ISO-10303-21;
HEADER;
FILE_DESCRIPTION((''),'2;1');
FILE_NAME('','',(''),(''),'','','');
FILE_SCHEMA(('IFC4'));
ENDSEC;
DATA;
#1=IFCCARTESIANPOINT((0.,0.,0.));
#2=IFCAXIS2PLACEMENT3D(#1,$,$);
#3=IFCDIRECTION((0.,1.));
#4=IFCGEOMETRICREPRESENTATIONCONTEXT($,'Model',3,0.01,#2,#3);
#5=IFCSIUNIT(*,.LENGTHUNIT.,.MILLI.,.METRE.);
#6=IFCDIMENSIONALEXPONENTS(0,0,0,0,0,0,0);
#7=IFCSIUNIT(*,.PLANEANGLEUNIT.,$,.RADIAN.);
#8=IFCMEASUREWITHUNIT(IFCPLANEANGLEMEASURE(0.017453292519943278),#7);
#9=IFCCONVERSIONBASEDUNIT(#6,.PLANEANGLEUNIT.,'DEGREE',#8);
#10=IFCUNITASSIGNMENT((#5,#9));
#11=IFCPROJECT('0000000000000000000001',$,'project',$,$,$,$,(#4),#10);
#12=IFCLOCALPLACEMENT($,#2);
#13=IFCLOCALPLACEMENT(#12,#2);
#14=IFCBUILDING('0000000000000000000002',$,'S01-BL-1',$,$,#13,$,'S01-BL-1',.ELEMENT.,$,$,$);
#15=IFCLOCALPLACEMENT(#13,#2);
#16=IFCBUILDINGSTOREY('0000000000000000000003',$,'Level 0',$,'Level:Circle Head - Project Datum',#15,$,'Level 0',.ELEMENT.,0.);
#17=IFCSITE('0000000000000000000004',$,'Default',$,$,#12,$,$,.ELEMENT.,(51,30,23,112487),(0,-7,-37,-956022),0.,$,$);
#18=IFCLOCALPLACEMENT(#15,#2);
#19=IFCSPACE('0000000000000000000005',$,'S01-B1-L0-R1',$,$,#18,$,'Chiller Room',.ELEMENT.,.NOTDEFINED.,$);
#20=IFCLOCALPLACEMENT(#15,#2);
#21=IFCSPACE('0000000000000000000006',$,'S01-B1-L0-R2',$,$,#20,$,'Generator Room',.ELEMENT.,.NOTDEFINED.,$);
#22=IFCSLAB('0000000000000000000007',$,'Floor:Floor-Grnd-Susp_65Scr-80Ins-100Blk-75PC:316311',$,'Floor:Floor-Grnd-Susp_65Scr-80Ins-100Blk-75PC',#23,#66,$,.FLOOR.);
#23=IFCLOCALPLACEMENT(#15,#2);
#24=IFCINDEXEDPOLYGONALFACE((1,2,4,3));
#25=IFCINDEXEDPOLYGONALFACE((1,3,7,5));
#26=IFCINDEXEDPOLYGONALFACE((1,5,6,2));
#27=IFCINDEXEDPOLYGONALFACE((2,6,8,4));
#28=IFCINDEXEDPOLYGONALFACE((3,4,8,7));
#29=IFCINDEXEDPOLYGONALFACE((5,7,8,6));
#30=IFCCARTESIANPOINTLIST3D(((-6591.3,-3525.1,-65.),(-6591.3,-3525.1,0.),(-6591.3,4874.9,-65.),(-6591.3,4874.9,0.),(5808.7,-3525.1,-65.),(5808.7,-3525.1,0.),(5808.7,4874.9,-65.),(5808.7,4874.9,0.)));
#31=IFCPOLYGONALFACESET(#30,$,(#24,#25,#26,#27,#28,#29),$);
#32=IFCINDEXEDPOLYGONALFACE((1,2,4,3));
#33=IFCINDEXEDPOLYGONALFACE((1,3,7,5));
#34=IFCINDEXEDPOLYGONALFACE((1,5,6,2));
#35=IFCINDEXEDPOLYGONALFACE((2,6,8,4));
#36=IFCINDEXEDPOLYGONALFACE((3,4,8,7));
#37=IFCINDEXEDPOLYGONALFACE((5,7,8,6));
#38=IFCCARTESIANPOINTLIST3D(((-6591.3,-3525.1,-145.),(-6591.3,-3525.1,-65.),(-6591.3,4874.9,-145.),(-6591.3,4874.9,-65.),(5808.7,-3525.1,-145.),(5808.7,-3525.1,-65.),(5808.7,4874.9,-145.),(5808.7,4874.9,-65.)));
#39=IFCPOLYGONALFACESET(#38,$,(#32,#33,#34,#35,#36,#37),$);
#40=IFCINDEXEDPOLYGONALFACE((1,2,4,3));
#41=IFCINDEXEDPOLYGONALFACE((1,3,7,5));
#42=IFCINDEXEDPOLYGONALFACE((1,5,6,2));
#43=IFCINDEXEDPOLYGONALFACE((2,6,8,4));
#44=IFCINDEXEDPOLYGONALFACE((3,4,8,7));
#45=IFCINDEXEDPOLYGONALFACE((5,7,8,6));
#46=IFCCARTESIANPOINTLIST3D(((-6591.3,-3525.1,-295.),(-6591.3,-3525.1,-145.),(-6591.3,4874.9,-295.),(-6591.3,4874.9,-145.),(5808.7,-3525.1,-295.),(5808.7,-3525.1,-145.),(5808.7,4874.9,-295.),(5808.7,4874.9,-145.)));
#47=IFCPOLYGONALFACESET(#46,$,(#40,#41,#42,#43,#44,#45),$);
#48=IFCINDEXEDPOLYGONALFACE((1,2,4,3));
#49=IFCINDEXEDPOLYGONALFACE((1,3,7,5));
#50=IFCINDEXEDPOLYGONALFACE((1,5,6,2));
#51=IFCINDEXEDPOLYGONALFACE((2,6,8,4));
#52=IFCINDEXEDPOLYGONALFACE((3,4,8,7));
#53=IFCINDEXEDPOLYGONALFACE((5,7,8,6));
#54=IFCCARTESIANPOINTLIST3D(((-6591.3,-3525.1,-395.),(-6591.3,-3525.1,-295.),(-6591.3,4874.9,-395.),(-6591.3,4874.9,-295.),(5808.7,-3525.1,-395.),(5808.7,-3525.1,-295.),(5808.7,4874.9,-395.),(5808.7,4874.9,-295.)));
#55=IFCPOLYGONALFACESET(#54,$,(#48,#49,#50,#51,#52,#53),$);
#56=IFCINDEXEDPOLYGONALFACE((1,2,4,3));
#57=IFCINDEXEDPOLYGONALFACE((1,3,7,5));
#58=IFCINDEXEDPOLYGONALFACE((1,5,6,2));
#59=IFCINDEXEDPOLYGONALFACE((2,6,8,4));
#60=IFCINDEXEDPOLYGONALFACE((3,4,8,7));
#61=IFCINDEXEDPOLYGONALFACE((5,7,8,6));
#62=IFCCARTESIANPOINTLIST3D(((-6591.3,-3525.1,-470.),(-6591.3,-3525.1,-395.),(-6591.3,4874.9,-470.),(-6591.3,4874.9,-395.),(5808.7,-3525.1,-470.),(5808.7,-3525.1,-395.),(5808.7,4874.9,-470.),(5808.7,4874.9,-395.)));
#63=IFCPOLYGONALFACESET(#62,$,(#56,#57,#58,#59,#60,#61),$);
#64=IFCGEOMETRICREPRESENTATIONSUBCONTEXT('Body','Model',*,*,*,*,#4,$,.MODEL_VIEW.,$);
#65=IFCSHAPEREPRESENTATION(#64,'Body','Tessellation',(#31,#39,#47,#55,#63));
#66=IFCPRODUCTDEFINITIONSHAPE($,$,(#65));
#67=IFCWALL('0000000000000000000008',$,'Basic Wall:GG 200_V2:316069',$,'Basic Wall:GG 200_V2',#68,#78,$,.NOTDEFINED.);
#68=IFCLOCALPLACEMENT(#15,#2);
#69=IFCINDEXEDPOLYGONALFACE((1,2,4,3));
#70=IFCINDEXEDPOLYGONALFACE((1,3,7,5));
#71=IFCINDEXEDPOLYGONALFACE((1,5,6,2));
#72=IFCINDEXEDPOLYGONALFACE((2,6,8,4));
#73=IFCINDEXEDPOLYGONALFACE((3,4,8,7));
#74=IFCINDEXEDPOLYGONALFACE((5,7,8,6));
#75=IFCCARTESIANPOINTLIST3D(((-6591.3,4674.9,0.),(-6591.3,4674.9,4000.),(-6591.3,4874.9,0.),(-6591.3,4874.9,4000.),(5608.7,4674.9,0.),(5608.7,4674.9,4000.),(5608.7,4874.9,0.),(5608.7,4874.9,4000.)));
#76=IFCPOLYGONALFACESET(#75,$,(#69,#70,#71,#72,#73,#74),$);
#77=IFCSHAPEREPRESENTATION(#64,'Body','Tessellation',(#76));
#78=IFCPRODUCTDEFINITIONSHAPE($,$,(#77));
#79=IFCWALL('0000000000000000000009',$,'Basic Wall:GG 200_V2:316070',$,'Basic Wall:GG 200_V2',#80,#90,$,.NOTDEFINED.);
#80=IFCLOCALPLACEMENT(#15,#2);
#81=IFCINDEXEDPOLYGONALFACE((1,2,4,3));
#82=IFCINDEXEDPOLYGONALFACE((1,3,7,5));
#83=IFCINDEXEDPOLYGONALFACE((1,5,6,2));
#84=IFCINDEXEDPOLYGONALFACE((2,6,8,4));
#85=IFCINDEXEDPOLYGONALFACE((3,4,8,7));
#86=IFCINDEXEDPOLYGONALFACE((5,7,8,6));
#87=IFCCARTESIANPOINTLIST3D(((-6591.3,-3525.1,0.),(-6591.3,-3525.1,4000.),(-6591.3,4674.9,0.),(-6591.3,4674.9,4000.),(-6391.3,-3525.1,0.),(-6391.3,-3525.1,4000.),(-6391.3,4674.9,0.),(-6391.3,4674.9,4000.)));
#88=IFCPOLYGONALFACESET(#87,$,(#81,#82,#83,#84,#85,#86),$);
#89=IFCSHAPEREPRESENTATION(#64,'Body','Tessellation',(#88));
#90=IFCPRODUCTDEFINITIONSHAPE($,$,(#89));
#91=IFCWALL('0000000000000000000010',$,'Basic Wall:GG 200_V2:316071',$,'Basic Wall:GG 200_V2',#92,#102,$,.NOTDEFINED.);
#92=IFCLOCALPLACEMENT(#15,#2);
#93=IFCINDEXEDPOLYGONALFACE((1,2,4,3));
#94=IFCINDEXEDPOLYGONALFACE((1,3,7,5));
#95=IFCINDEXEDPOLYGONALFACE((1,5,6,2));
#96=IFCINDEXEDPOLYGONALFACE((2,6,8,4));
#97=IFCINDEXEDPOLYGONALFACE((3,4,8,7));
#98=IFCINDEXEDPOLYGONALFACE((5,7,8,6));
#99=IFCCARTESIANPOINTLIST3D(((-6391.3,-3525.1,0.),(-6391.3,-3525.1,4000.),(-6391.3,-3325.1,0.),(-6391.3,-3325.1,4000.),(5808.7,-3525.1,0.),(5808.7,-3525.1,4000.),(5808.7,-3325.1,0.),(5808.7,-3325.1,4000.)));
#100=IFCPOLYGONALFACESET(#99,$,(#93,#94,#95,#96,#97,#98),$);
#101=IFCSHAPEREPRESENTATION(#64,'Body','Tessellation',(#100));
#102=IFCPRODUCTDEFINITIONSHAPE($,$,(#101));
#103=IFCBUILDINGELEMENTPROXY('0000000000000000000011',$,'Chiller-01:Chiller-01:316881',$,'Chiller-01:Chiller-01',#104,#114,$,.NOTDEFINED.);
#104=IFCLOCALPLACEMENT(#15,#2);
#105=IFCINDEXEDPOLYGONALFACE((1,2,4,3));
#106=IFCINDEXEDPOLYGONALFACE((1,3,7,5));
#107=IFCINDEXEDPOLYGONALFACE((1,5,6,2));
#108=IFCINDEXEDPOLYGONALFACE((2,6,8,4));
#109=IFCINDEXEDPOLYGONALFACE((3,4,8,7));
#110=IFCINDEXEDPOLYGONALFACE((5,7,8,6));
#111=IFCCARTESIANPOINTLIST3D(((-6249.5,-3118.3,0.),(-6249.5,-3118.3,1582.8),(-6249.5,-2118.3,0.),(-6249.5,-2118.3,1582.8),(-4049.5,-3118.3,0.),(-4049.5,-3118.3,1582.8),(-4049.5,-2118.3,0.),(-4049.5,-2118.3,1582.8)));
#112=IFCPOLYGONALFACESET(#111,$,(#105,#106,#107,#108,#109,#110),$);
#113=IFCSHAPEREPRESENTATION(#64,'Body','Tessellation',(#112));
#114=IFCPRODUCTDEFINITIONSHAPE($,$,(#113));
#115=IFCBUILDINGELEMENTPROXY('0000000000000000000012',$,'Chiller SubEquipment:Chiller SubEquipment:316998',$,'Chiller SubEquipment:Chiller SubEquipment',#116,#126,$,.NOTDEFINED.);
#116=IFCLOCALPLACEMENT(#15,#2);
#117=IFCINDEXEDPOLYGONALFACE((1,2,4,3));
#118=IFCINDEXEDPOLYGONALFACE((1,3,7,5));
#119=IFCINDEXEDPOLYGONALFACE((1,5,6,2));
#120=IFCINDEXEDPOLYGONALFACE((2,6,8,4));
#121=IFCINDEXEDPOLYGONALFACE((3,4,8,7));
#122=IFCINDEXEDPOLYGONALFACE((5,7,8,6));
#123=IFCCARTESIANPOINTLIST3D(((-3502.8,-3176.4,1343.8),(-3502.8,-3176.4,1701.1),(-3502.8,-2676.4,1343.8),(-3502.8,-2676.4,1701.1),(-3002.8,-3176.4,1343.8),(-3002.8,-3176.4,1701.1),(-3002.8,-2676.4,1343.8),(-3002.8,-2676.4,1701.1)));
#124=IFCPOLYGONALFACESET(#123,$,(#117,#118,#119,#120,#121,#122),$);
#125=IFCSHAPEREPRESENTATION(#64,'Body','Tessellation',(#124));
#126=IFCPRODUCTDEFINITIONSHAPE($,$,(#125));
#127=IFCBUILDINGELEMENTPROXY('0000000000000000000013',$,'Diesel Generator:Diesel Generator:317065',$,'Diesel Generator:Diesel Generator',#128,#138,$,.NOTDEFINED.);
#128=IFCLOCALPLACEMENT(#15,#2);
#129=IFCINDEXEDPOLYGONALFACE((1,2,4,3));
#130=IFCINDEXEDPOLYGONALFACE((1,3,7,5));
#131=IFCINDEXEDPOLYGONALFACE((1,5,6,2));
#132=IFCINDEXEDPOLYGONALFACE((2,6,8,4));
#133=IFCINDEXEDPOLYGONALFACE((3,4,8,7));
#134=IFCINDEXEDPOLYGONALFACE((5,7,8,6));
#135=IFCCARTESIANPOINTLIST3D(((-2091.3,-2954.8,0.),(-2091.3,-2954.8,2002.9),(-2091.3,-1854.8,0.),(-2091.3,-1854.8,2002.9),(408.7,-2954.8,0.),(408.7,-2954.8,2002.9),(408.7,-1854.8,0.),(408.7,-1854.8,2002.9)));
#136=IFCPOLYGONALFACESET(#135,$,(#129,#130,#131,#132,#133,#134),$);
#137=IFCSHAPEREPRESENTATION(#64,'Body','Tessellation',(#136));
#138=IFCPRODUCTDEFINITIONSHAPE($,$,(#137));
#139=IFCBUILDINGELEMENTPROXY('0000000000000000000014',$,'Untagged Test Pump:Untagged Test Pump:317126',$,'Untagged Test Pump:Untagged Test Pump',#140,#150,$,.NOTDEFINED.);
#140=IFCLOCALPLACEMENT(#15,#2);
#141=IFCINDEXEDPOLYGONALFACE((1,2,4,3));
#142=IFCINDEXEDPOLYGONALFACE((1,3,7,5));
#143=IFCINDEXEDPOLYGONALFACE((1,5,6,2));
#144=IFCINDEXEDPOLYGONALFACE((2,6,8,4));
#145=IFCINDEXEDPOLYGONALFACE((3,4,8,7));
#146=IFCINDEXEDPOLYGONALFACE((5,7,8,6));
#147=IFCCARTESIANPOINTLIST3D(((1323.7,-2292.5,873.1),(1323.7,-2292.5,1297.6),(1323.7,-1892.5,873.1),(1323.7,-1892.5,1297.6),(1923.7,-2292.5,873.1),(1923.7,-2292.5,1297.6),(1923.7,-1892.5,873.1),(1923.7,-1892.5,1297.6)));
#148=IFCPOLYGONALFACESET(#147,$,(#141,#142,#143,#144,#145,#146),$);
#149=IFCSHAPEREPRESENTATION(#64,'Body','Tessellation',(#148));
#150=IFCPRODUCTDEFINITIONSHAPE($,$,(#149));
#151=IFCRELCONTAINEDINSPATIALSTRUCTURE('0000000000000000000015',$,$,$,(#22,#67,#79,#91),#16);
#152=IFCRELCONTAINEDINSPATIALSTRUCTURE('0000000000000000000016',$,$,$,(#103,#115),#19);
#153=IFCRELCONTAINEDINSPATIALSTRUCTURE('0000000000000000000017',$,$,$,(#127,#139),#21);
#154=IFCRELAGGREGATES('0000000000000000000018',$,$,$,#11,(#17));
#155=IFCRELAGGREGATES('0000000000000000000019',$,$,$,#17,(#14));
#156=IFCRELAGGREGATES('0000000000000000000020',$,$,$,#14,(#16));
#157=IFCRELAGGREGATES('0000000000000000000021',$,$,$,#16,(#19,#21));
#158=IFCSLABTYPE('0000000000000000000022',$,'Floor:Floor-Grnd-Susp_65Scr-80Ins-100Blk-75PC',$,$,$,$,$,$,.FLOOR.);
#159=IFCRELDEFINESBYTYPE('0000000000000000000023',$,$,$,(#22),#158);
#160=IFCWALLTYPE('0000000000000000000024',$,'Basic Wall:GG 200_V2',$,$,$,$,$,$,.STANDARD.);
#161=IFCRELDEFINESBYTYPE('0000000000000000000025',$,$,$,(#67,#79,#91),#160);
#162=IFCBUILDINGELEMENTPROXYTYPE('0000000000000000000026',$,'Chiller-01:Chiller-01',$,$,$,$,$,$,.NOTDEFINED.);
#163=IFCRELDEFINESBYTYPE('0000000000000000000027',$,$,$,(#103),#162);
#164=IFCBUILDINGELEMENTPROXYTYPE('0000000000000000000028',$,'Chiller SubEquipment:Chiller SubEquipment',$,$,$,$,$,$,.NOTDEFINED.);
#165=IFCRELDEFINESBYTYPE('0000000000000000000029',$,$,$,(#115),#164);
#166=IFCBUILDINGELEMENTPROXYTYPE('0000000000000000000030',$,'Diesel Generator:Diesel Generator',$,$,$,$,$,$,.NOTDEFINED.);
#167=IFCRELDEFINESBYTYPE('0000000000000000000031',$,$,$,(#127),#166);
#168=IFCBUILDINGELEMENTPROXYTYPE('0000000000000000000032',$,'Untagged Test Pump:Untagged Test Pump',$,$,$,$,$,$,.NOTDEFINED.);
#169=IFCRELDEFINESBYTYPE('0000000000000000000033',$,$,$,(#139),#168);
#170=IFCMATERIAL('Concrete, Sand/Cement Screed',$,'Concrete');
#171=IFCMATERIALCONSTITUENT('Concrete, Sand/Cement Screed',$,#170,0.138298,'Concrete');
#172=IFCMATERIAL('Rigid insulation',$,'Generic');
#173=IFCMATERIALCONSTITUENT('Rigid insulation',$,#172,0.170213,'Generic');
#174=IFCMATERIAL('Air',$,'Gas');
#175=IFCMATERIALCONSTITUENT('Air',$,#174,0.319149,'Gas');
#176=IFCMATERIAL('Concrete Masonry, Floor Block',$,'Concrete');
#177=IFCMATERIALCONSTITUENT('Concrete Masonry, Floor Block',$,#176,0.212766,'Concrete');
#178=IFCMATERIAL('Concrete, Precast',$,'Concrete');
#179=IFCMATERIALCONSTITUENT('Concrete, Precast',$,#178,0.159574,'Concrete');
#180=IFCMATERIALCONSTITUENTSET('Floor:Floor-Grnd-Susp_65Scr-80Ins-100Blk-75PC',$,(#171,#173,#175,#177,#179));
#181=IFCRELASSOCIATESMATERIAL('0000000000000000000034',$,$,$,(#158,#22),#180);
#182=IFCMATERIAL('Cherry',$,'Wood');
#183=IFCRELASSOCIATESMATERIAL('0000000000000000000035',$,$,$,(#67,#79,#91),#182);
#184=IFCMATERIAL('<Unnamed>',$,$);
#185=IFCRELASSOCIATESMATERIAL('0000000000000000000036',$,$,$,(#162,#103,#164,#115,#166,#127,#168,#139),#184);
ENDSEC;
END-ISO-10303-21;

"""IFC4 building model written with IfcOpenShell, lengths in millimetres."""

from ifc_helpers import new_model, entity, si_unit, converted_unit, direction, frame, origin, place, context, subcontext, project, spatial, indexed_curve, outline, extrude, source, transform, mapped, material, constituent, constituent_set, type_object, type_shapes, element, save


model = new_model("IFC4")

# Units and contexts
model_context = context("Model", 3, precision=0.01, world=origin(), true_north=direction((0.0, 1.0)))
body_context = subcontext(model_context, "Body", "Model", "MODEL_VIEW")
ifc_project = project(units=[si_unit("LENGTHUNIT", "METRE", prefix="MILLI"), converted_unit("PLANEANGLEUNIT", "DEGREE", entity("IfcPlaneAngleMeasure", 0.017453292519943278), si_unit("PLANEANGLEUNIT", "RADIAN"), dimensions=[0, 0, 0, 0, 0, 0, 0])], contexts=[model_context])

# Site, building, storey
site_placement = place(None, origin())
site = spatial("IfcSite", under=ifc_project, at=site_placement, Name="Default", CompositionType="ELEMENT", RefLatitude=(51, 30, 23, 112487), RefLongitude=(0, -7, -37, -956022), RefElevation=0.0)
building_placement = place(site_placement, origin())
building = spatial("IfcBuilding", under=site, at=building_placement, Name="S01-BL-1", LongName="S01-BL-1", CompositionType="ELEMENT")
storey_placement = place(building_placement, origin())
storey = spatial("IfcBuildingStorey", under=building, at=storey_placement, Name="Level 0", ObjectType="Level:Circle Head - Project Datum", LongName="Level 0", CompositionType="ELEMENT", Elevation=0.0)

# Slab
ifc_material_1 = material(Name="Concrete, Sand/Cement Screed", Category="Concrete")
ifc_constituent_1 = constituent(ifc_material_1, Name="Concrete, Sand/Cement Screed", Category="Concrete", fraction=0.138298)
ifc_material_2 = material(Name="Rigid insulation", Category="Generic")
ifc_constituent_2 = constituent(ifc_material_2, Name="Rigid insulation", Category="Generic", fraction=0.170213)
ifc_material_3 = material(Name="Air", Category="Gas")
ifc_constituent_3 = constituent(ifc_material_3, Name="Air", Category="Gas", fraction=0.319149)
ifc_material_4 = material(Name="Concrete Masonry, Floor Block", Category="Concrete")
ifc_constituent_4 = constituent(ifc_material_4, Name="Concrete Masonry, Floor Block", Category="Concrete", fraction=0.212766)
ifc_material_5 = material(Name="Concrete, Precast", Category="Concrete")
ifc_constituent_5 = constituent(ifc_material_5, Name="Concrete, Precast", Category="Concrete", fraction=0.159574)
ifc_constituent_set = constituent_set(constituents=[ifc_constituent_1, ifc_constituent_2, ifc_constituent_3, ifc_constituent_4, ifc_constituent_5], Name="Floor:Floor-Grnd-Susp_65Scr-80Ins-100Blk-75PC")
slab_type = type_object("IfcSlabType", Name="Floor:Floor-Grnd-Susp_65Scr-80Ins-100Blk-75PC", PredefinedType="FLOOR", material=ifc_constituent_set)
slab_placement = place(storey_placement, origin())
element("IfcSlab", 1, at=slab_placement, inside=storey, type_object=slab_type, material=ifc_constituent_set, Name="Floor:Floor-Grnd-Susp_65Scr-80Ins-100Blk-75PC:316311", ObjectType="Floor:Floor-Grnd-Susp_65Scr-80Ins-100Blk-75PC", PredefinedType="FLOOR", context=body_context, shape_type="SweptSolid", body=[
    extrude(outline(indexed_curve([(-6200.0, -4200.0), (6200.0, -4200.0), (6200.0, 4200.0), (-6200.0, 4200.0), (-6200.0, -4200.0)], self_intersect=False)), frame((-391.3, 674.9, -65.0), z_axis=(0.0, 0.0, 1.0), x_axis=(-1.0, 0.0, 0.0)), (0.0, 0.0, 1.0), 65.0),
    extrude(outline(indexed_curve([(-6200.0, -4200.0), (6200.0, -4200.0), (6200.0, 4200.0), (-6200.0, 4200.0), (-6200.0, -4200.0)], self_intersect=False)), frame((-391.3, 674.9, -145.0), z_axis=(0.0, 0.0, 1.0), x_axis=(-1.0, 0.0, 0.0)), (0.0, 0.0, 1.0), 80.0),
    extrude(outline(indexed_curve([(-6200.0, -4200.0), (6200.0, -4200.0), (6200.0, 4200.0), (-6200.0, 4200.0), (-6200.0, -4200.0)], self_intersect=False)), frame((-391.3, 674.9, -295.0), z_axis=(0.0, 0.0, 1.0), x_axis=(-1.0, 0.0, 0.0)), (0.0, 0.0, 1.0), 150.0),
    extrude(outline(indexed_curve([(-6200.0, -4200.0), (6200.0, -4200.0), (6200.0, 4200.0), (-6200.0, 4200.0), (-6200.0, -4200.0)], self_intersect=False)), frame((-391.3, 674.9, -395.0), z_axis=(0.0, 0.0, 1.0), x_axis=(-1.0, 0.0, 0.0)), (0.0, 0.0, 1.0), 100.0),
    extrude(outline(indexed_curve([(-6200.0, -4200.0), (6200.0, -4200.0), (6200.0, 4200.0), (-6200.0, 4200.0), (-6200.0, -4200.0)], self_intersect=False)), frame((-391.3, 674.9, -470.0), z_axis=(0.0, 0.0, 1.0), x_axis=(-1.0, 0.0, 0.0)), (0.0, 0.0, 1.0), 75.0),
])

# Walls
ifc_material_6 = material(Name="Cherry", Category="Wood")
wall_type = type_object("IfcWallType", Name="Basic Wall:GG 200_V2", PredefinedType="STANDARD")
wall_1_placement = place(storey_placement, frame((-6591.3, 4774.9, 0.0)))
element("IfcWall", 2, at=wall_1_placement, inside=storey, type_object=wall_type, material=ifc_material_6, Name="Basic Wall:GG 200_V2:316069", ObjectType="Basic Wall:GG 200_V2", PredefinedType="NOTDEFINED", context=body_context, shape_type="SweptSolid", body=[
    extrude(outline(indexed_curve([(12200.0, 100.0), (0.0, 100.0), (0.0, -100.0), (12200.0, -100.0), (12200.0, 100.0)], self_intersect=False)), origin(), (0.0, 0.0, 1.0), 4000.0),
])
wall_2_placement = place(storey_placement, frame((-6491.3, -3525.1, 0.0), z_axis=(0.0, 0.0, 1.0), x_axis=(0.0, 1.0, 0.0)))
element("IfcWall", 3, at=wall_2_placement, inside=storey, type_object=wall_type, material=ifc_material_6, Name="Basic Wall:GG 200_V2:316070", ObjectType="Basic Wall:GG 200_V2", PredefinedType="NOTDEFINED", context=body_context, shape_type="SweptSolid", body=[
    extrude(outline(indexed_curve([(8200.0, 100.0), (0.0, 100.0), (0.0, -100.0), (8200.0, -100.0), (8200.0, 100.0)], self_intersect=False)), origin(), (0.0, 0.0, 1.0), 4000.0),
])
wall_3_placement = place(storey_placement, frame((5808.7, -3425.1, 0.0), z_axis=(0.0, 0.0, 1.0), x_axis=(-1.0, 0.0, 0.0)))
element("IfcWall", 4, at=wall_3_placement, inside=storey, type_object=wall_type, material=ifc_material_6, Name="Basic Wall:GG 200_V2:316071", ObjectType="Basic Wall:GG 200_V2", PredefinedType="NOTDEFINED", context=body_context, shape_type="SweptSolid", body=[
    extrude(outline(indexed_curve([(12200.0, 100.0), (0.0, 100.0), (0.0, -100.0), (12200.0, -100.0), (12200.0, 100.0)], self_intersect=False)), origin(), (0.0, 0.0, 1.0), 4000.0),
])

# Shared definitions
space_1_placement = place(storey_placement, origin())
space_1 = spatial("IfcSpace", under=storey, at=space_1_placement, Name="S01-B1-L0-R1", LongName="Chiller Room", CompositionType="ELEMENT", PredefinedType="NOTDEFINED")

# Building element proxies
ifc_material_7 = material(Name="<Unnamed>")
building_element_proxy_type_1 = type_object("IfcBuildingElementProxyType", Name="Chiller-01:Chiller-01", PredefinedType="NOTDEFINED", material=ifc_material_7)
shared_shape_1 = source(origin(), body_context, "Body", "SweptSolid", [
    extrude(outline(indexed_curve([(-1100.0, -500.0), (1100.0, -500.0), (1100.0, 500.0), (-1100.0, 500.0), (-1100.0, -500.0)], self_intersect=False)), frame((-5149.5, -2618.3, 0.0), z_axis=(0.0, 0.0, 1.0), x_axis=(-1.0, 0.0, 0.0)), (0.0, 0.0, 1.0), 1582.8),
])
type_shapes(building_element_proxy_type_1, [shared_shape_1])
proxy_1_placement = place(space_1_placement, origin())
element("IfcBuildingElementProxy", 5, at=proxy_1_placement, inside=space_1, type_object=building_element_proxy_type_1, material=ifc_material_7, Name="Chiller-01:Chiller-01:316881", ObjectType="Chiller-01:Chiller-01", PredefinedType="NOTDEFINED", context=body_context, shape_type="MappedRepresentation", body=[
    mapped(shared_shape_1, transform((0.0, 0.0, 0.0), scale=1.0)),
])
building_element_proxy_type_2 = type_object("IfcBuildingElementProxyType", Name="Chiller SubEquipment:Chiller SubEquipment", PredefinedType="NOTDEFINED", material=ifc_material_7)
shared_shape_2 = source(origin(), body_context, "Body", "SweptSolid", [
    extrude(outline(indexed_curve([(-250.0, -250.0), (250.0, -250.0), (250.0, 250.0), (-250.0, 250.0), (-250.0, -250.0)], self_intersect=False)), frame((-3252.8, -2849.1, 1343.8), z_axis=(0.0, 0.0, 1.0), x_axis=(-1.0, 0.0, 0.0)), (0.0, 0.0, 1.0), 357.3),
])
type_shapes(building_element_proxy_type_2, [shared_shape_2])
proxy_2_placement = place(space_1_placement, frame((0.0, -77.3, 0.0)))
element("IfcBuildingElementProxy", 6, at=proxy_2_placement, inside=space_1, type_object=building_element_proxy_type_2, material=ifc_material_7, Name="Chiller SubEquipment:Chiller SubEquipment:316998", ObjectType="Chiller SubEquipment:Chiller SubEquipment", PredefinedType="NOTDEFINED", context=body_context, shape_type="MappedRepresentation", body=[
    mapped(shared_shape_2, transform((0.0, 0.0, 0.0), scale=1.0)),
])

# Shared definitions
space_2_placement = place(storey_placement, origin())
space_2 = spatial("IfcSpace", under=storey, at=space_2_placement, Name="S01-B1-L0-R2", LongName="Generator Room", CompositionType="ELEMENT", PredefinedType="NOTDEFINED")

# Building element proxies
building_element_proxy_type_3 = type_object("IfcBuildingElementProxyType", Name="Diesel Generator:Diesel Generator", PredefinedType="NOTDEFINED", material=ifc_material_7)
shared_shape_3 = source(origin(), body_context, "Body", "SweptSolid", [
    extrude(outline(indexed_curve([(-1250.0, -550.0), (1250.0, -550.0), (1250.0, 550.0), (-1250.0, 550.0), (-1250.0, -550.0)], self_intersect=False)), frame((-841.3, -2404.8, 0.0), z_axis=(0.0, 0.0, 1.0), x_axis=(-1.0, 0.0, 0.0)), (0.0, 0.0, 1.0), 2002.9),
])
type_shapes(building_element_proxy_type_3, [shared_shape_3])
proxy_3_placement = place(space_2_placement, origin())
element("IfcBuildingElementProxy", 7, at=proxy_3_placement, inside=space_2, type_object=building_element_proxy_type_3, material=ifc_material_7, Name="Diesel Generator:Diesel Generator:317065", ObjectType="Diesel Generator:Diesel Generator", PredefinedType="NOTDEFINED", context=body_context, shape_type="MappedRepresentation", body=[
    mapped(shared_shape_3, transform((0.0, 0.0, 0.0), scale=1.0)),
])
building_element_proxy_type_4 = type_object("IfcBuildingElementProxyType", Name="Untagged Test Pump:Untagged Test Pump", PredefinedType="NOTDEFINED", material=ifc_material_7)
shared_shape_4 = source(origin(), body_context, "Body", "SweptSolid", [
    extrude(outline(indexed_curve([(-300.0, -200.0), (300.0, -200.0), (300.0, 200.0), (-300.0, 200.0), (-300.0, -200.0)], self_intersect=False)), frame((1623.7, -2092.5, 873.1), z_axis=(0.0, 0.0, 1.0), x_axis=(-1.0, 0.0, 0.0)), (0.0, 0.0, 1.0), 424.4),
])
type_shapes(building_element_proxy_type_4, [shared_shape_4])
proxy_4_placement = place(space_2_placement, origin())
element("IfcBuildingElementProxy", 8, at=proxy_4_placement, inside=space_2, type_object=building_element_proxy_type_4, material=ifc_material_7, Name="Untagged Test Pump:Untagged Test Pump:317126", ObjectType="Untagged Test Pump:Untagged Test Pump", PredefinedType="NOTDEFINED", context=body_context, shape_type="MappedRepresentation", body=[
    mapped(shared_shape_4, transform((0.0, 0.0, 0.0), scale=1.0)),
])

save(model, "model.ifc")
